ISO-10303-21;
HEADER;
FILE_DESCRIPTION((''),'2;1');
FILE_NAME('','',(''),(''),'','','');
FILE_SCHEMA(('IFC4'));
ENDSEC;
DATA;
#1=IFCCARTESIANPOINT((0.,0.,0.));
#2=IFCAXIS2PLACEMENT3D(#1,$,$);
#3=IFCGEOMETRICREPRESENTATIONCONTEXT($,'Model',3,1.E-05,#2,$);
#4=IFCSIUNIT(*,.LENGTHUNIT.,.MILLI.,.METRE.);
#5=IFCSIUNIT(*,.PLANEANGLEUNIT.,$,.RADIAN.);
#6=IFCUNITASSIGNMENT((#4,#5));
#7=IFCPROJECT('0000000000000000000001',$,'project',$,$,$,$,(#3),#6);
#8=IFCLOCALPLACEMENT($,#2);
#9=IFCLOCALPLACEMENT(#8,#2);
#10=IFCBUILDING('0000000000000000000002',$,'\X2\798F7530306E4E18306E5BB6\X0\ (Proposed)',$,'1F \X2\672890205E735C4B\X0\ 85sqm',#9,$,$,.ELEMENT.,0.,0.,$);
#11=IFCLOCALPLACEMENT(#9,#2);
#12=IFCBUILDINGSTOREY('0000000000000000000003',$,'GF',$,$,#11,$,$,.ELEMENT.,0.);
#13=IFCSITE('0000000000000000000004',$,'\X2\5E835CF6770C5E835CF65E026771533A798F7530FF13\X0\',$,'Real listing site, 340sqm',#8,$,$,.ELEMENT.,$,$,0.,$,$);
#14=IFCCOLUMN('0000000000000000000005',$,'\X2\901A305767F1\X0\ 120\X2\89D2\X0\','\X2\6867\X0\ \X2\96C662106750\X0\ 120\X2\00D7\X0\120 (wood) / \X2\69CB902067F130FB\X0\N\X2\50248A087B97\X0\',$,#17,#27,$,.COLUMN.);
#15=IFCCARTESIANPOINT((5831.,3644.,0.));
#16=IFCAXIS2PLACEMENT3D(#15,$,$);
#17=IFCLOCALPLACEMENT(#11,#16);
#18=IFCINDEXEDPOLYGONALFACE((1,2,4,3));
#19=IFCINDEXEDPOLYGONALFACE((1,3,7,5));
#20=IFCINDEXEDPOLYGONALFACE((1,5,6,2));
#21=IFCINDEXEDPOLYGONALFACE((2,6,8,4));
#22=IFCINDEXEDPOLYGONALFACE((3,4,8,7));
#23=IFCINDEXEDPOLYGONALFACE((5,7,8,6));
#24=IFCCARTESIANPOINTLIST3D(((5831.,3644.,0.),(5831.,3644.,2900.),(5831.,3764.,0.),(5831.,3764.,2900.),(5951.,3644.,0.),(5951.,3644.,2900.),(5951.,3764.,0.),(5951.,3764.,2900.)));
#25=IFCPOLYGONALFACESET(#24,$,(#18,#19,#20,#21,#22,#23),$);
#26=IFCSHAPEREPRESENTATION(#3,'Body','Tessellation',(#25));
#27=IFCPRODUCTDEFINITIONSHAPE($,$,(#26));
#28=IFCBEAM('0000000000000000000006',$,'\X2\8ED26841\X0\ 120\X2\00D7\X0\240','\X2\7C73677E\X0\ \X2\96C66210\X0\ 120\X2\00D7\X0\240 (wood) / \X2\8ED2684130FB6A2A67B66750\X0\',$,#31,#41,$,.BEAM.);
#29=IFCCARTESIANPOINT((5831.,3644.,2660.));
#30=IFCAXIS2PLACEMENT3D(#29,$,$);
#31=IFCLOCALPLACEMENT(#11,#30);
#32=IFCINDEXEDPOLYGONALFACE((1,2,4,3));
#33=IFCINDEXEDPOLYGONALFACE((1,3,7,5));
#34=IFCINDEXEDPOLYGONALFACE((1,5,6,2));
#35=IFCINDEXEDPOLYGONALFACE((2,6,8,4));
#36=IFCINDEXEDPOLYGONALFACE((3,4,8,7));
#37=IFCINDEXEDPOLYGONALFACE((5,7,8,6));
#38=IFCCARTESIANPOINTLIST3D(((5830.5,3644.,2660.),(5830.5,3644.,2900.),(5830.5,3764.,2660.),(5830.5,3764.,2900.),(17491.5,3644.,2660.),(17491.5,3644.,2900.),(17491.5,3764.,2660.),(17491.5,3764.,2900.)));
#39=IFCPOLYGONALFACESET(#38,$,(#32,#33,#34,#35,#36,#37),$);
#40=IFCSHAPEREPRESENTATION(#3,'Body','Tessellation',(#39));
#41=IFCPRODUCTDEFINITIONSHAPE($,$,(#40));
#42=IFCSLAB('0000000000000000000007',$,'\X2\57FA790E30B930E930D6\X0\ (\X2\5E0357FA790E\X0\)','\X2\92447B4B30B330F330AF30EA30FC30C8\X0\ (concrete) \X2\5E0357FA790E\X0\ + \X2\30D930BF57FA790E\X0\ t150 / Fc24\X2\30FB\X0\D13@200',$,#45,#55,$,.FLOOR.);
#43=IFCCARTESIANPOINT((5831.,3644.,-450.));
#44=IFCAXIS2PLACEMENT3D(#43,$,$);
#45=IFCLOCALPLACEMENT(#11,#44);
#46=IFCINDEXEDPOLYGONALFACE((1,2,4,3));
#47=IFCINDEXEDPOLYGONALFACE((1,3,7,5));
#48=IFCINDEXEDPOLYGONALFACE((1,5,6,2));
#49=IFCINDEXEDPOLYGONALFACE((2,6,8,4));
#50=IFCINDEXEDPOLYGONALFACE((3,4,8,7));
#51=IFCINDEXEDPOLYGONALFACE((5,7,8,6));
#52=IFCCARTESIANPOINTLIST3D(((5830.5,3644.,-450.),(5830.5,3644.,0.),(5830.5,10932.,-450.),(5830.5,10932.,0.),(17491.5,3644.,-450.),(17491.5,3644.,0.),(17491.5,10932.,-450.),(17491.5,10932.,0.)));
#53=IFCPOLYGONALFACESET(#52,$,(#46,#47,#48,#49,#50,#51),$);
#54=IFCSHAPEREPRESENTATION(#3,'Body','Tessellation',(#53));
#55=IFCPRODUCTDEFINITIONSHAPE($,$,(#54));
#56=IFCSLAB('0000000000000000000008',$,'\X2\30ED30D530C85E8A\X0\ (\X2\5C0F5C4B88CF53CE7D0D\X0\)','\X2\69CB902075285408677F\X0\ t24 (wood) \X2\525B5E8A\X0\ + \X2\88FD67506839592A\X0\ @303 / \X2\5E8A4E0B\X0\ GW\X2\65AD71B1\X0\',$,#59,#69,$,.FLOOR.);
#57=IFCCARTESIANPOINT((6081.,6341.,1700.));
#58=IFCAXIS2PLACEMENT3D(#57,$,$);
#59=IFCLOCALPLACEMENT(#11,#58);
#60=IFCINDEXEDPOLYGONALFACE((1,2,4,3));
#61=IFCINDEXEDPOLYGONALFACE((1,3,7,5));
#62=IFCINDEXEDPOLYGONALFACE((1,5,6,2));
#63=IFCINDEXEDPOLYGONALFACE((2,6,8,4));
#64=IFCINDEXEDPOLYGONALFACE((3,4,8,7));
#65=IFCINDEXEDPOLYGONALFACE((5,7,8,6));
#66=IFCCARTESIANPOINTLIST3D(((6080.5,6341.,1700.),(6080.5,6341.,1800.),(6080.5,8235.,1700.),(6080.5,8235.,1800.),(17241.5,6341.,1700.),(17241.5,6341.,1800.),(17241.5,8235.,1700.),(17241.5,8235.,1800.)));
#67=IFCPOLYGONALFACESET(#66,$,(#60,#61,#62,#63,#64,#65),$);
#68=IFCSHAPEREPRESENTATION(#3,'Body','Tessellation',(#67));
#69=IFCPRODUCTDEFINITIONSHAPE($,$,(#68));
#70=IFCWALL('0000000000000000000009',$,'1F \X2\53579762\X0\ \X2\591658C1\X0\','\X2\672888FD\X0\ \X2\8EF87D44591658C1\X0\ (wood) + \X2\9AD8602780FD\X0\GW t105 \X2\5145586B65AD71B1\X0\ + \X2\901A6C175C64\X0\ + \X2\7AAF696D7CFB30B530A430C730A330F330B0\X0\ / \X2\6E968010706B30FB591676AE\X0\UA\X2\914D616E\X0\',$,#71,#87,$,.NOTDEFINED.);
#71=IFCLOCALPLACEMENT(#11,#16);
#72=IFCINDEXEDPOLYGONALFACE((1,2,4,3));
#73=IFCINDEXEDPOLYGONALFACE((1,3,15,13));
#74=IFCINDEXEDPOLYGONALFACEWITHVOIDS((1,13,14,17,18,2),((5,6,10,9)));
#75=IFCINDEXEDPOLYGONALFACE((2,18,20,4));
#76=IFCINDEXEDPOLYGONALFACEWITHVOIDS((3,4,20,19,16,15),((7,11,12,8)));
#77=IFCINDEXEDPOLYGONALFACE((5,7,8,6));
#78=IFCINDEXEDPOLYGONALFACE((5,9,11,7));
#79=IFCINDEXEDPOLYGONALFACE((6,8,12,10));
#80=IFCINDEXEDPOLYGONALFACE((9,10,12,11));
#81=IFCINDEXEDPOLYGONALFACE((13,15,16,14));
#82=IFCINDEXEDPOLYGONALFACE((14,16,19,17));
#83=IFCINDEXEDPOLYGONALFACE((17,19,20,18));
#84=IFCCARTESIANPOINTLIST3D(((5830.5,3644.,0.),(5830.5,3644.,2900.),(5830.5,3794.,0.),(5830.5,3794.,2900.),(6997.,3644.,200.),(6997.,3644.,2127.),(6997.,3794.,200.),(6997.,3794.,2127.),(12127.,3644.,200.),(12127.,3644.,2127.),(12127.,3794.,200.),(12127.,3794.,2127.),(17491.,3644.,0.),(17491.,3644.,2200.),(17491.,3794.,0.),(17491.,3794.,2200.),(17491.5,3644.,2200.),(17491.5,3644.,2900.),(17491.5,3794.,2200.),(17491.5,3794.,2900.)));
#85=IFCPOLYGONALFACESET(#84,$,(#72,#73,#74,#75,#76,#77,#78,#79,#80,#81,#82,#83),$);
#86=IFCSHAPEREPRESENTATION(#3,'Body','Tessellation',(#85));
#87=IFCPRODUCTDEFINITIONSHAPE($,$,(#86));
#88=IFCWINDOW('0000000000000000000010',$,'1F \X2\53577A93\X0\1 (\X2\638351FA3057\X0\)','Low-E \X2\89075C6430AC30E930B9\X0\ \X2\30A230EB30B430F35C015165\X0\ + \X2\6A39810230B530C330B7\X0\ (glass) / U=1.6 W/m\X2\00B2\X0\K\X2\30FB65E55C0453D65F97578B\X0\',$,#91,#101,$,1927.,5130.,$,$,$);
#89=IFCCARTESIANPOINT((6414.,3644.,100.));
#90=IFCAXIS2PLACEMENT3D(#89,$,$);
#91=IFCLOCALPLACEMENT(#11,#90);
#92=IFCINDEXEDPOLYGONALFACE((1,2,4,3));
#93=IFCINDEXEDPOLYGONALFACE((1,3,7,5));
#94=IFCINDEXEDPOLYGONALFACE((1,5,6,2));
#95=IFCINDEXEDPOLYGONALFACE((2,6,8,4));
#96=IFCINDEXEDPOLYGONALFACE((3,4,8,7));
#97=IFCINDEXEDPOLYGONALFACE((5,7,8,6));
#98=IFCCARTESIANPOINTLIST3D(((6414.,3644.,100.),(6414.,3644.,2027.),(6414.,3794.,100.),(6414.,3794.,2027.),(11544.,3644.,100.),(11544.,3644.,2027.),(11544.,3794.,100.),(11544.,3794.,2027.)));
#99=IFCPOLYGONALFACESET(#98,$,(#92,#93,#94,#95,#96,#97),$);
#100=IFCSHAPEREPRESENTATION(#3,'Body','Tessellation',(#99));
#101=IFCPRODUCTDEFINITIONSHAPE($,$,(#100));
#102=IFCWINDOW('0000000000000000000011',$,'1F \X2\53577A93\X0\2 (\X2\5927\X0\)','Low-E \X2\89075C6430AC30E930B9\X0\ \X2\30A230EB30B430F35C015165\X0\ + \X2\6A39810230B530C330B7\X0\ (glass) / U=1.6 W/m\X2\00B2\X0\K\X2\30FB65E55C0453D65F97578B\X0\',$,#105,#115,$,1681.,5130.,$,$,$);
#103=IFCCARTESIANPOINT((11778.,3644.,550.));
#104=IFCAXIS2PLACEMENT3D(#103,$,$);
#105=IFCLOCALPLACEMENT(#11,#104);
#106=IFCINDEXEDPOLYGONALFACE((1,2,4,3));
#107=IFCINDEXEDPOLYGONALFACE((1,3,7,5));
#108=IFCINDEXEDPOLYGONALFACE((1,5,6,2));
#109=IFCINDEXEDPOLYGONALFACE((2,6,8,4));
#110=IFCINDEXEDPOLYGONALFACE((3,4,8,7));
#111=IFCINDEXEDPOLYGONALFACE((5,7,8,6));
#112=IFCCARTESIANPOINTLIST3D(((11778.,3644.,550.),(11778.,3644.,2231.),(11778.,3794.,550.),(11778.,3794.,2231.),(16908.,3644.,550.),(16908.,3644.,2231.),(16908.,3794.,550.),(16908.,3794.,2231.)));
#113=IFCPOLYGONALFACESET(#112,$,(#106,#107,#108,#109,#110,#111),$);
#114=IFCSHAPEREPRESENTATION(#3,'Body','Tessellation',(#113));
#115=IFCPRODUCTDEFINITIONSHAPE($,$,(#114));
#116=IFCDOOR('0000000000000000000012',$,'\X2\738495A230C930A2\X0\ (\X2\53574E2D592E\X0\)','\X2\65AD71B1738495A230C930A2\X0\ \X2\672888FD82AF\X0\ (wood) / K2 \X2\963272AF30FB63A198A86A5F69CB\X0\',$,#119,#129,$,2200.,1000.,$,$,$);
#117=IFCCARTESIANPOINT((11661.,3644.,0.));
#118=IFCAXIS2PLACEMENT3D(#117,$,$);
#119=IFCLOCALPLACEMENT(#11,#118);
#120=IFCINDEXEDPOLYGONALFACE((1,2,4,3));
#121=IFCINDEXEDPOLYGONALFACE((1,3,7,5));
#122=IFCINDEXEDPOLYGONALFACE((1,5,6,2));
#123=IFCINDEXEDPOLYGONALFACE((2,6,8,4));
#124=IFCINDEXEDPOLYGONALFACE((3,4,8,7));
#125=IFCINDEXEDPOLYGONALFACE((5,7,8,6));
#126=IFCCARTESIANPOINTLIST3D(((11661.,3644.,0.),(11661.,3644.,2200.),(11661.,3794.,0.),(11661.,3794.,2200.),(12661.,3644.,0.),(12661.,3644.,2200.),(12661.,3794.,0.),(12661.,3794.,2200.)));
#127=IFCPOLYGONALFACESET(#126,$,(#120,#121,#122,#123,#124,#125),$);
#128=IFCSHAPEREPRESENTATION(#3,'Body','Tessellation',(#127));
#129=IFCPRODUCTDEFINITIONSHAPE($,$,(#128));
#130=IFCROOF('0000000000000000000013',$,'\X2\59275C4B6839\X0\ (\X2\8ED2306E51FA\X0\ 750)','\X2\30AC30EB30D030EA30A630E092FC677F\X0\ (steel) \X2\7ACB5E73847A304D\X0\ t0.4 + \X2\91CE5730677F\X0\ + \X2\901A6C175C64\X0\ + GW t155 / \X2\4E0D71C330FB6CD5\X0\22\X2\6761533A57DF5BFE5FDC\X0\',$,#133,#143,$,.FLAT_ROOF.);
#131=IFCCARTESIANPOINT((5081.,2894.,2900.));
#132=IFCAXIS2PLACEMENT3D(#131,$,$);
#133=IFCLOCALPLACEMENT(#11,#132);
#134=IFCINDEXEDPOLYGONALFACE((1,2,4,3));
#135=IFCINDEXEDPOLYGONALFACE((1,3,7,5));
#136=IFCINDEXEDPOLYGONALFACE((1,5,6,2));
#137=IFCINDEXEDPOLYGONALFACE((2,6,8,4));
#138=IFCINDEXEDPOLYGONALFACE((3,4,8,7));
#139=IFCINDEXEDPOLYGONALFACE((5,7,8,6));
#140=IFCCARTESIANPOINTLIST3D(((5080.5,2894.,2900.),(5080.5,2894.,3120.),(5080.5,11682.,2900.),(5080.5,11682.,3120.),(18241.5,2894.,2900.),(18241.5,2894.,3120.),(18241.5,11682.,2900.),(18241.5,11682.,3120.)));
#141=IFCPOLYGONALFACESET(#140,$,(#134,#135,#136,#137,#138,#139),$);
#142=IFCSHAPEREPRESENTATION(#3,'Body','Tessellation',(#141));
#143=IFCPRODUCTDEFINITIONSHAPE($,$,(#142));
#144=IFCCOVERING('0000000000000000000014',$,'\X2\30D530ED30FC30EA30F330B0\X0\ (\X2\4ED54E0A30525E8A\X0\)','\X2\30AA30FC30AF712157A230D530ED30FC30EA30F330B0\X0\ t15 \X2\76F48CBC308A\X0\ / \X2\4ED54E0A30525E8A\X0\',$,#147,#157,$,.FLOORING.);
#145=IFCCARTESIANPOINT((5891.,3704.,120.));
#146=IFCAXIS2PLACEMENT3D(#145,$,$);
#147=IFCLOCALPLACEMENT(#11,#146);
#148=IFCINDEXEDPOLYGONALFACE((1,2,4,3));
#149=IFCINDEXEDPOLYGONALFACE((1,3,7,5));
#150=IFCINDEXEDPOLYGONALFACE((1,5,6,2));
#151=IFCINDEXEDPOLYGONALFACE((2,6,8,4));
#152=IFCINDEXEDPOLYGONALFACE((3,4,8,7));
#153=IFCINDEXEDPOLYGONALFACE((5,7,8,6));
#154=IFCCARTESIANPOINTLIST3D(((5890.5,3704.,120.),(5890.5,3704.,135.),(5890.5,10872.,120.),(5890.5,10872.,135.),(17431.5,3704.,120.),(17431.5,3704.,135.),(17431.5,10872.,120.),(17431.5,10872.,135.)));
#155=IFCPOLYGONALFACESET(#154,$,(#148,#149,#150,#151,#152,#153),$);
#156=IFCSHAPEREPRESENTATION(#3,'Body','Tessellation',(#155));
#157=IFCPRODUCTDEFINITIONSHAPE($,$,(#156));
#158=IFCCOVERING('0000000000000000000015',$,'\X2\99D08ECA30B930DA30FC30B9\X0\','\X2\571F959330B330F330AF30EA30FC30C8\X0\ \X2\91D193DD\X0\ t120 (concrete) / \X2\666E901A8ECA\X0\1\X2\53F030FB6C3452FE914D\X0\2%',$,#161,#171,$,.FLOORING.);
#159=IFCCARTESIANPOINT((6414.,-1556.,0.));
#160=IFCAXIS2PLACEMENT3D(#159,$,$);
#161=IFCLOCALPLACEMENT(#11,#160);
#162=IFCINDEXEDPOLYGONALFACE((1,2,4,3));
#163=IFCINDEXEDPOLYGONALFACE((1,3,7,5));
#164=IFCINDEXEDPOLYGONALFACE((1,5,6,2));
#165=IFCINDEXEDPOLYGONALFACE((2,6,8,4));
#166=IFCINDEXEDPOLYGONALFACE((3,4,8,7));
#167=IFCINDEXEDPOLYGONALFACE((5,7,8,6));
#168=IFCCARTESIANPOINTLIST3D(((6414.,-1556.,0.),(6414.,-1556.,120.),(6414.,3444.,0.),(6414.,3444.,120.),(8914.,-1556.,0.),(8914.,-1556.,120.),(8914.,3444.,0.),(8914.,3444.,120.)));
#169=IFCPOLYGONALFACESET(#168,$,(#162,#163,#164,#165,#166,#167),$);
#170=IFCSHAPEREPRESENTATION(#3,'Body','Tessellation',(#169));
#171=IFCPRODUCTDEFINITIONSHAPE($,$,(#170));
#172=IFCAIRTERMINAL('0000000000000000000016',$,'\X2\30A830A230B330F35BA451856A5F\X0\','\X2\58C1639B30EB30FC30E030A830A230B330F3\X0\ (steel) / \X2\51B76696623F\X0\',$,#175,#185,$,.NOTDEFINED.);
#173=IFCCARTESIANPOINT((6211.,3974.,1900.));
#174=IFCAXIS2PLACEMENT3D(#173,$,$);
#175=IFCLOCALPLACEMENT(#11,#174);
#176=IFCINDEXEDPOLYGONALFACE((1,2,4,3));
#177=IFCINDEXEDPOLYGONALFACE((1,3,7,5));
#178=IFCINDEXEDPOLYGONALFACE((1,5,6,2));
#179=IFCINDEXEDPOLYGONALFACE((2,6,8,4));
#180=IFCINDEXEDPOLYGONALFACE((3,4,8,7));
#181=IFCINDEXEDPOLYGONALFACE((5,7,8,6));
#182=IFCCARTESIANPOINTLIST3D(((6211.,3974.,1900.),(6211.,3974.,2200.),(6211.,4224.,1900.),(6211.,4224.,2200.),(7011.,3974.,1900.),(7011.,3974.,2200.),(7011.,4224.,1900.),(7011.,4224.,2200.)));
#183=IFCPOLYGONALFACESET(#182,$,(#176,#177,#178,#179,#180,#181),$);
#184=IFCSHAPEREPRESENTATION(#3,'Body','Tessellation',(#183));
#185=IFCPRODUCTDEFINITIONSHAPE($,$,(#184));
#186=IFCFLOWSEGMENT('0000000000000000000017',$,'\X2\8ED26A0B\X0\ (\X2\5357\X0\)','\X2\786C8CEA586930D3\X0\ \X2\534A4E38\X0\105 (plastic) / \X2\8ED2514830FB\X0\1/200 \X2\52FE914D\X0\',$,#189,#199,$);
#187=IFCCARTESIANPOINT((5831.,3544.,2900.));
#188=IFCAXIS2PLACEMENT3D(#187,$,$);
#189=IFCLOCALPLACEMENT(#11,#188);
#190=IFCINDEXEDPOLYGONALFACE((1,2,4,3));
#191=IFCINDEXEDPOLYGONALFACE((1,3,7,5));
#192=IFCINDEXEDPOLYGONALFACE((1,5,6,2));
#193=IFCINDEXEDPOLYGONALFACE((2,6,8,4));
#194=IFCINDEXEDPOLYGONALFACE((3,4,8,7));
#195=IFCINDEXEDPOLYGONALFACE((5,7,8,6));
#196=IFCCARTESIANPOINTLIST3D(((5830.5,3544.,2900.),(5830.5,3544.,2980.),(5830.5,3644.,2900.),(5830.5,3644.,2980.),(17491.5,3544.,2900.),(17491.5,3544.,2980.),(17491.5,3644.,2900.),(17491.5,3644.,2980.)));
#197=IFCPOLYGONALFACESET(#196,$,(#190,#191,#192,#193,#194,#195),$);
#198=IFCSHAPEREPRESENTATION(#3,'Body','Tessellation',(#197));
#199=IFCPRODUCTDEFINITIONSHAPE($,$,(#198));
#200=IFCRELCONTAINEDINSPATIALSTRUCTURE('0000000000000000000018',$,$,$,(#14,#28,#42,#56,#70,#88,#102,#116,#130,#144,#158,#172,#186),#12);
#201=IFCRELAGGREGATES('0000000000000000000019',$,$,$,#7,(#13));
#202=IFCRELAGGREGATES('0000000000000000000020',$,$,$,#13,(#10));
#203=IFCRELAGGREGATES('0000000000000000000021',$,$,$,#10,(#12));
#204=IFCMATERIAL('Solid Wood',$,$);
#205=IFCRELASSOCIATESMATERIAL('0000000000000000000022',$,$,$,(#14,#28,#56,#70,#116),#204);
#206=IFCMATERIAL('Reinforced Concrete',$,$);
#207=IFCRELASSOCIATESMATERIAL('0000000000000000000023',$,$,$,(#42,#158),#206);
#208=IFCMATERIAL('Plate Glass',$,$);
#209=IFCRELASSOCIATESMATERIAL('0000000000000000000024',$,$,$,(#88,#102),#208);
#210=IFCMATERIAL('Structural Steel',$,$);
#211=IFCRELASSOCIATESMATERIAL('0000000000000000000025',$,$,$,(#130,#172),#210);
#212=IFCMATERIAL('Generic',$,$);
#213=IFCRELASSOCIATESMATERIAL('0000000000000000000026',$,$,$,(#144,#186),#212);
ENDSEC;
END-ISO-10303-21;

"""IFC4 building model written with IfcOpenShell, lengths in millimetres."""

from ifc_helpers import new_model, si_unit, frame, frame_2d, origin, place, context, project, spatial, rectangle, extrude, material, element, fill, save


model = new_model("IFC4")

# Units and contexts
model_context = context("Model", 3, precision=1e-05, world=origin())
ifc_project = project(units=[si_unit("LENGTHUNIT", "METRE", prefix="MILLI"), si_unit("PLANEANGLEUNIT", "RADIAN")], contexts=[model_context])

# Site, building, storey
site_placement = place(None, origin())
site = spatial("IfcSite", under=ifc_project, at=site_placement, Name="広島県広島市東区福田３", ObjectType="Real listing site, 340sqm", CompositionType="ELEMENT", RefElevation=0.0)
building_placement = place(site_placement, origin())
building = spatial("IfcBuilding", under=site, at=building_placement, Name="福田の丘の家 (Proposed)", ObjectType="1F 木造平屋 85sqm", CompositionType="ELEMENT", ElevationOfRefHeight=0.0, ElevationOfTerrain=0.0)
storey_placement = place(building_placement, origin())
storey = spatial("IfcBuildingStorey", under=building, at=storey_placement, Name="GF", CompositionType="ELEMENT", Elevation=0.0)

# Column
ifc_material_1 = material(Name="Solid Wood")
column_1_placement = place(storey_placement, frame((5831.0, 3644.0, 0.0)))
element("IfcColumn", 1, at=column_1_placement, inside=storey, material=ifc_material_1, Name="通し柱 120角", Description="桧 集成材 120×120 (wood) / 構造柱・N値計算", PredefinedType="COLUMN", context=model_context, shape_type="SweptSolid", body=[
    extrude(rectangle(XDim=120.0, YDim=120.0, at=frame_2d((60.0, 60.0))), frame((5831.0, 3644.0, 0.0)), (0.0, 0.0, 1.0), 2900.0),
])

# Beam
beam_1_placement = place(storey_placement, frame((5831.0, 3644.0, 2660.0)))
element("IfcBeam", 2, at=beam_1_placement, inside=storey, material=ifc_material_1, Name="軒桁 120×240", Description="米松 集成 120×240 (wood) / 軒桁・横架材", PredefinedType="BEAM", context=model_context, shape_type="SweptSolid", body=[
    extrude(rectangle(XDim=11661.0, YDim=120.0, at=frame_2d((5830.0, 60.0))), frame((5831.0, 3644.0, 2660.0)), (0.0, 0.0, 1.0), 240.0),
])

# Slabs
ifc_material_2 = material(Name="Reinforced Concrete")
slab_1_placement = place(storey_placement, frame((5831.0, 3644.0, -450.0)))
element("IfcSlab", 3, at=slab_1_placement, inside=storey, material=ifc_material_2, Name="基礎スラブ (布基礎)", Description="鉄筋コンクリート (concrete) 布基礎 + ベタ基礎 t150 / Fc24・D13@200", PredefinedType="FLOOR", context=model_context, shape_type="SweptSolid", body=[
    extrude(rectangle(XDim=11661.0, YDim=7288.0, at=frame_2d((5830.0, 3644.0))), frame((5831.0, 3644.0, -450.0)), (0.0, 0.0, 1.0), 450.0),
])
slab_2_placement = place(storey_placement, frame((6081.0, 6341.0, 1700.0)))
element("IfcSlab", 4, at=slab_2_placement, inside=storey, material=ifc_material_1, Name="ロフト床 (小屋裏収納)", Description="構造用合板 t24 (wood) 剛床 + 製材根太 @303 / 床下 GW断熱", PredefinedType="FLOOR", context=model_context, shape_type="SweptSolid", body=[
    extrude(rectangle(XDim=11161.0, YDim=1894.0, at=frame_2d((5580.0, 947.0))), frame((6081.0, 6341.0, 1700.0)), (0.0, 0.0, 1.0), 100.0),
])

# Wall, openings, windows, door
wall_1_placement = place(storey_placement, frame((5831.0, 3644.0, 0.0)))
wall_1 = element("IfcWall", 5, at=wall_1_placement, inside=storey, material=ifc_material_1, Name="1F 南面 外壁", Description="木製 軸組外壁 (wood) + 高性能GW t105 充填断熱 + 通気層 + 窯業系サイディング / 準耐火・外皮UA配慮", PredefinedType="NOTDEFINED", context=model_context, shape_type="SweptSolid", body=[
    extrude(rectangle(XDim=11661.0, YDim=150.0, at=frame_2d((5830.0, 75.0))), frame((5831.0, 3644.0, 0.0)), (0.0, 0.0, 1.0), 2900.0),
])
opening_1_placement = place(storey_placement, frame((6414.0, 3644.0, 100.0)))
opening_1 = element("IfcOpeningElement", 6, at=opening_1_placement, cuts=wall_1, PredefinedType="NOTDEFINED", context=model_context, shape_type="SweptSolid", body=[
    extrude(rectangle(XDim=5130.0, YDim=150.0, at=frame_2d((2565.0, 75.0))), frame((6414.0, 3644.0, 100.0)), (0.0, 0.0, 1.0), 1927.0),
])
opening_2_placement = place(storey_placement, frame((11778.0, 3644.0, 550.0)))
opening_2 = element("IfcOpeningElement", 7, at=opening_2_placement, cuts=wall_1, PredefinedType="NOTDEFINED", context=model_context, shape_type="SweptSolid", body=[
    extrude(rectangle(XDim=5130.0, YDim=150.0, at=frame_2d((2565.0, 75.0))), frame((11778.0, 3644.0, 550.0)), (0.0, 0.0, 1.0), 1681.0),
])
opening_3_placement = place(storey_placement, frame((11661.0, 3644.0, 0.0)))
opening_3 = element("IfcOpeningElement", 8, at=opening_3_placement, cuts=wall_1, PredefinedType="NOTDEFINED", context=model_context, shape_type="SweptSolid", body=[
    extrude(rectangle(XDim=1000.0, YDim=150.0, at=frame_2d((500.0, 75.0))), frame((11661.0, 3644.0, 0.0)), (0.0, 0.0, 1.0), 2200.0),
])
ifc_material_3 = material(Name="Plate Glass")
window_1_placement = place(storey_placement, frame((6414.0, 3644.0, 100.0)))
window_1 = element("IfcWindow", 9, at=window_1_placement, inside=storey, material=ifc_material_3, Name="1F 南窓1 (掃出し)", Description="Low-E 複層ガラス アルゴン封入 + 樹脂サッシ (glass) / U=1.6 W/m²K・日射取得型", OverallHeight=1927.0, OverallWidth=5130.0, context=model_context, shape_type="SweptSolid", body=[
    extrude(rectangle(XDim=5130.0, YDim=150.0, at=frame_2d((2565.0, 75.0))), frame((6414.0, 3644.0, 100.0)), (0.0, 0.0, 1.0), 1927.0),
])
fill(opening_1, window_1)
window_2_placement = place(storey_placement, frame((11778.0, 3644.0, 550.0)))
window_2 = element("IfcWindow", 10, at=window_2_placement, inside=storey, material=ifc_material_3, Name="1F 南窓2 (大)", Description="Low-E 複層ガラス アルゴン封入 + 樹脂サッシ (glass) / U=1.6 W/m²K・日射取得型", OverallHeight=1681.0, OverallWidth=5130.0, context=model_context, shape_type="SweptSolid", body=[
    extrude(rectangle(XDim=5130.0, YDim=150.0, at=frame_2d((2565.0, 75.0))), frame((11778.0, 3644.0, 550.0)), (0.0, 0.0, 1.0), 1681.0),
])
fill(opening_2, window_2)
door_placement = place(storey_placement, frame((11661.0, 3644.0, 0.0)))
door = element("IfcDoor", 11, at=door_placement, inside=storey, material=ifc_material_1, Name="玄関ドア (南中央)", Description="断熱玄関ドア 木製芯 (wood) / K2 防犯・採風機構", OverallHeight=2200.0, OverallWidth=1000.0, context=model_context, shape_type="SweptSolid", body=[
    extrude(rectangle(XDim=1000.0, YDim=150.0, at=frame_2d((500.0, 75.0))), frame((11661.0, 3644.0, 0.0)), (0.0, 0.0, 1.0), 2200.0),
])
fill(opening_3, door)

# Roof
ifc_material_4 = material(Name="Structural Steel")
roof_placement = place(storey_placement, frame((5081.0, 2894.0, 2900.0)))
element("IfcRoof", 12, at=roof_placement, inside=storey, material=ifc_material_4, Name="大屋根 (軒の出 750)", Description="ガルバリウム鋼板 (steel) 立平葺き t0.4 + 野地板 + 通気層 + GW t155 / 不燃・法22条区域対応", PredefinedType="FLAT_ROOF", context=model_context, shape_type="SweptSolid", body=[
    extrude(rectangle(XDim=13161.0, YDim=8788.0, at=frame_2d((6580.0, 4394.0))), frame((5081.0, 2894.0, 2900.0)), (0.0, 0.0, 1.0), 220.0),
])

# Coverings
ifc_material_5 = material(Name="Generic")
covering_1_placement = place(storey_placement, frame((5891.0, 3704.0, 120.0)))
element("IfcCovering", 13, at=covering_1_placement, inside=storey, material=ifc_material_5, Name="フローリング (仕上げ床)", Description="オーク無垢フローリング t15 直貼り / 仕上げ床", PredefinedType="FLOORING", context=model_context, shape_type="SweptSolid", body=[
    extrude(rectangle(XDim=11541.0, YDim=7168.0, at=frame_2d((5770.0, 3584.0))), frame((5891.0, 3704.0, 120.0)), (0.0, 0.0, 1.0), 15.0),
])
covering_2_placement = place(storey_placement, frame((6414.0, -1556.0, 0.0)))
element("IfcCovering", 14, at=covering_2_placement, inside=storey, material=ifc_material_2, Name="駐車スペース", Description="土間コンクリート 金鏝 t120 (concrete) / 普通車1台・水勾配2%", PredefinedType="FLOORING", context=model_context, shape_type="SweptSolid", body=[
    extrude(rectangle(XDim=2500.0, YDim=5000.0, at=frame_2d((1250.0, 2500.0))), frame((6414.0, -1556.0, 0.0)), (0.0, 0.0, 1.0), 120.0),
])

# Air terminal
air_terminal_placement = place(storey_placement, frame((6211.0, 3974.0, 1900.0)))
element("IfcAirTerminal", 15, at=air_terminal_placement, inside=storey, material=ifc_material_4, Name="エアコン室内機", Description="壁掛ルームエアコン (steel) / 冷暖房", PredefinedType="NOTDEFINED", context=model_context, shape_type="SweptSolid", body=[
    extrude(rectangle(XDim=800.0, YDim=250.0, at=frame_2d((400.0, 125.0))), frame((6211.0, 3974.0, 1900.0)), (0.0, 0.0, 1.0), 300.0),
])

# Flow segment
flow_segment_1_placement = place(storey_placement, frame((5831.0, 3544.0, 2900.0)))
element("IfcFlowSegment", 16, at=flow_segment_1_placement, inside=storey, material=ifc_material_5, Name="軒樋 (南)", Description="硬質塩ビ 半丸105 (plastic) / 軒先・1/200 勾配", context=model_context, shape_type="SweptSolid", body=[
    extrude(rectangle(XDim=11661.0, YDim=100.0, at=frame_2d((5830.0, 50.0))), frame((5831.0, 3544.0, 2900.0)), (0.0, 0.0, 1.0), 80.0),
])

save(model, "model.ifc")
